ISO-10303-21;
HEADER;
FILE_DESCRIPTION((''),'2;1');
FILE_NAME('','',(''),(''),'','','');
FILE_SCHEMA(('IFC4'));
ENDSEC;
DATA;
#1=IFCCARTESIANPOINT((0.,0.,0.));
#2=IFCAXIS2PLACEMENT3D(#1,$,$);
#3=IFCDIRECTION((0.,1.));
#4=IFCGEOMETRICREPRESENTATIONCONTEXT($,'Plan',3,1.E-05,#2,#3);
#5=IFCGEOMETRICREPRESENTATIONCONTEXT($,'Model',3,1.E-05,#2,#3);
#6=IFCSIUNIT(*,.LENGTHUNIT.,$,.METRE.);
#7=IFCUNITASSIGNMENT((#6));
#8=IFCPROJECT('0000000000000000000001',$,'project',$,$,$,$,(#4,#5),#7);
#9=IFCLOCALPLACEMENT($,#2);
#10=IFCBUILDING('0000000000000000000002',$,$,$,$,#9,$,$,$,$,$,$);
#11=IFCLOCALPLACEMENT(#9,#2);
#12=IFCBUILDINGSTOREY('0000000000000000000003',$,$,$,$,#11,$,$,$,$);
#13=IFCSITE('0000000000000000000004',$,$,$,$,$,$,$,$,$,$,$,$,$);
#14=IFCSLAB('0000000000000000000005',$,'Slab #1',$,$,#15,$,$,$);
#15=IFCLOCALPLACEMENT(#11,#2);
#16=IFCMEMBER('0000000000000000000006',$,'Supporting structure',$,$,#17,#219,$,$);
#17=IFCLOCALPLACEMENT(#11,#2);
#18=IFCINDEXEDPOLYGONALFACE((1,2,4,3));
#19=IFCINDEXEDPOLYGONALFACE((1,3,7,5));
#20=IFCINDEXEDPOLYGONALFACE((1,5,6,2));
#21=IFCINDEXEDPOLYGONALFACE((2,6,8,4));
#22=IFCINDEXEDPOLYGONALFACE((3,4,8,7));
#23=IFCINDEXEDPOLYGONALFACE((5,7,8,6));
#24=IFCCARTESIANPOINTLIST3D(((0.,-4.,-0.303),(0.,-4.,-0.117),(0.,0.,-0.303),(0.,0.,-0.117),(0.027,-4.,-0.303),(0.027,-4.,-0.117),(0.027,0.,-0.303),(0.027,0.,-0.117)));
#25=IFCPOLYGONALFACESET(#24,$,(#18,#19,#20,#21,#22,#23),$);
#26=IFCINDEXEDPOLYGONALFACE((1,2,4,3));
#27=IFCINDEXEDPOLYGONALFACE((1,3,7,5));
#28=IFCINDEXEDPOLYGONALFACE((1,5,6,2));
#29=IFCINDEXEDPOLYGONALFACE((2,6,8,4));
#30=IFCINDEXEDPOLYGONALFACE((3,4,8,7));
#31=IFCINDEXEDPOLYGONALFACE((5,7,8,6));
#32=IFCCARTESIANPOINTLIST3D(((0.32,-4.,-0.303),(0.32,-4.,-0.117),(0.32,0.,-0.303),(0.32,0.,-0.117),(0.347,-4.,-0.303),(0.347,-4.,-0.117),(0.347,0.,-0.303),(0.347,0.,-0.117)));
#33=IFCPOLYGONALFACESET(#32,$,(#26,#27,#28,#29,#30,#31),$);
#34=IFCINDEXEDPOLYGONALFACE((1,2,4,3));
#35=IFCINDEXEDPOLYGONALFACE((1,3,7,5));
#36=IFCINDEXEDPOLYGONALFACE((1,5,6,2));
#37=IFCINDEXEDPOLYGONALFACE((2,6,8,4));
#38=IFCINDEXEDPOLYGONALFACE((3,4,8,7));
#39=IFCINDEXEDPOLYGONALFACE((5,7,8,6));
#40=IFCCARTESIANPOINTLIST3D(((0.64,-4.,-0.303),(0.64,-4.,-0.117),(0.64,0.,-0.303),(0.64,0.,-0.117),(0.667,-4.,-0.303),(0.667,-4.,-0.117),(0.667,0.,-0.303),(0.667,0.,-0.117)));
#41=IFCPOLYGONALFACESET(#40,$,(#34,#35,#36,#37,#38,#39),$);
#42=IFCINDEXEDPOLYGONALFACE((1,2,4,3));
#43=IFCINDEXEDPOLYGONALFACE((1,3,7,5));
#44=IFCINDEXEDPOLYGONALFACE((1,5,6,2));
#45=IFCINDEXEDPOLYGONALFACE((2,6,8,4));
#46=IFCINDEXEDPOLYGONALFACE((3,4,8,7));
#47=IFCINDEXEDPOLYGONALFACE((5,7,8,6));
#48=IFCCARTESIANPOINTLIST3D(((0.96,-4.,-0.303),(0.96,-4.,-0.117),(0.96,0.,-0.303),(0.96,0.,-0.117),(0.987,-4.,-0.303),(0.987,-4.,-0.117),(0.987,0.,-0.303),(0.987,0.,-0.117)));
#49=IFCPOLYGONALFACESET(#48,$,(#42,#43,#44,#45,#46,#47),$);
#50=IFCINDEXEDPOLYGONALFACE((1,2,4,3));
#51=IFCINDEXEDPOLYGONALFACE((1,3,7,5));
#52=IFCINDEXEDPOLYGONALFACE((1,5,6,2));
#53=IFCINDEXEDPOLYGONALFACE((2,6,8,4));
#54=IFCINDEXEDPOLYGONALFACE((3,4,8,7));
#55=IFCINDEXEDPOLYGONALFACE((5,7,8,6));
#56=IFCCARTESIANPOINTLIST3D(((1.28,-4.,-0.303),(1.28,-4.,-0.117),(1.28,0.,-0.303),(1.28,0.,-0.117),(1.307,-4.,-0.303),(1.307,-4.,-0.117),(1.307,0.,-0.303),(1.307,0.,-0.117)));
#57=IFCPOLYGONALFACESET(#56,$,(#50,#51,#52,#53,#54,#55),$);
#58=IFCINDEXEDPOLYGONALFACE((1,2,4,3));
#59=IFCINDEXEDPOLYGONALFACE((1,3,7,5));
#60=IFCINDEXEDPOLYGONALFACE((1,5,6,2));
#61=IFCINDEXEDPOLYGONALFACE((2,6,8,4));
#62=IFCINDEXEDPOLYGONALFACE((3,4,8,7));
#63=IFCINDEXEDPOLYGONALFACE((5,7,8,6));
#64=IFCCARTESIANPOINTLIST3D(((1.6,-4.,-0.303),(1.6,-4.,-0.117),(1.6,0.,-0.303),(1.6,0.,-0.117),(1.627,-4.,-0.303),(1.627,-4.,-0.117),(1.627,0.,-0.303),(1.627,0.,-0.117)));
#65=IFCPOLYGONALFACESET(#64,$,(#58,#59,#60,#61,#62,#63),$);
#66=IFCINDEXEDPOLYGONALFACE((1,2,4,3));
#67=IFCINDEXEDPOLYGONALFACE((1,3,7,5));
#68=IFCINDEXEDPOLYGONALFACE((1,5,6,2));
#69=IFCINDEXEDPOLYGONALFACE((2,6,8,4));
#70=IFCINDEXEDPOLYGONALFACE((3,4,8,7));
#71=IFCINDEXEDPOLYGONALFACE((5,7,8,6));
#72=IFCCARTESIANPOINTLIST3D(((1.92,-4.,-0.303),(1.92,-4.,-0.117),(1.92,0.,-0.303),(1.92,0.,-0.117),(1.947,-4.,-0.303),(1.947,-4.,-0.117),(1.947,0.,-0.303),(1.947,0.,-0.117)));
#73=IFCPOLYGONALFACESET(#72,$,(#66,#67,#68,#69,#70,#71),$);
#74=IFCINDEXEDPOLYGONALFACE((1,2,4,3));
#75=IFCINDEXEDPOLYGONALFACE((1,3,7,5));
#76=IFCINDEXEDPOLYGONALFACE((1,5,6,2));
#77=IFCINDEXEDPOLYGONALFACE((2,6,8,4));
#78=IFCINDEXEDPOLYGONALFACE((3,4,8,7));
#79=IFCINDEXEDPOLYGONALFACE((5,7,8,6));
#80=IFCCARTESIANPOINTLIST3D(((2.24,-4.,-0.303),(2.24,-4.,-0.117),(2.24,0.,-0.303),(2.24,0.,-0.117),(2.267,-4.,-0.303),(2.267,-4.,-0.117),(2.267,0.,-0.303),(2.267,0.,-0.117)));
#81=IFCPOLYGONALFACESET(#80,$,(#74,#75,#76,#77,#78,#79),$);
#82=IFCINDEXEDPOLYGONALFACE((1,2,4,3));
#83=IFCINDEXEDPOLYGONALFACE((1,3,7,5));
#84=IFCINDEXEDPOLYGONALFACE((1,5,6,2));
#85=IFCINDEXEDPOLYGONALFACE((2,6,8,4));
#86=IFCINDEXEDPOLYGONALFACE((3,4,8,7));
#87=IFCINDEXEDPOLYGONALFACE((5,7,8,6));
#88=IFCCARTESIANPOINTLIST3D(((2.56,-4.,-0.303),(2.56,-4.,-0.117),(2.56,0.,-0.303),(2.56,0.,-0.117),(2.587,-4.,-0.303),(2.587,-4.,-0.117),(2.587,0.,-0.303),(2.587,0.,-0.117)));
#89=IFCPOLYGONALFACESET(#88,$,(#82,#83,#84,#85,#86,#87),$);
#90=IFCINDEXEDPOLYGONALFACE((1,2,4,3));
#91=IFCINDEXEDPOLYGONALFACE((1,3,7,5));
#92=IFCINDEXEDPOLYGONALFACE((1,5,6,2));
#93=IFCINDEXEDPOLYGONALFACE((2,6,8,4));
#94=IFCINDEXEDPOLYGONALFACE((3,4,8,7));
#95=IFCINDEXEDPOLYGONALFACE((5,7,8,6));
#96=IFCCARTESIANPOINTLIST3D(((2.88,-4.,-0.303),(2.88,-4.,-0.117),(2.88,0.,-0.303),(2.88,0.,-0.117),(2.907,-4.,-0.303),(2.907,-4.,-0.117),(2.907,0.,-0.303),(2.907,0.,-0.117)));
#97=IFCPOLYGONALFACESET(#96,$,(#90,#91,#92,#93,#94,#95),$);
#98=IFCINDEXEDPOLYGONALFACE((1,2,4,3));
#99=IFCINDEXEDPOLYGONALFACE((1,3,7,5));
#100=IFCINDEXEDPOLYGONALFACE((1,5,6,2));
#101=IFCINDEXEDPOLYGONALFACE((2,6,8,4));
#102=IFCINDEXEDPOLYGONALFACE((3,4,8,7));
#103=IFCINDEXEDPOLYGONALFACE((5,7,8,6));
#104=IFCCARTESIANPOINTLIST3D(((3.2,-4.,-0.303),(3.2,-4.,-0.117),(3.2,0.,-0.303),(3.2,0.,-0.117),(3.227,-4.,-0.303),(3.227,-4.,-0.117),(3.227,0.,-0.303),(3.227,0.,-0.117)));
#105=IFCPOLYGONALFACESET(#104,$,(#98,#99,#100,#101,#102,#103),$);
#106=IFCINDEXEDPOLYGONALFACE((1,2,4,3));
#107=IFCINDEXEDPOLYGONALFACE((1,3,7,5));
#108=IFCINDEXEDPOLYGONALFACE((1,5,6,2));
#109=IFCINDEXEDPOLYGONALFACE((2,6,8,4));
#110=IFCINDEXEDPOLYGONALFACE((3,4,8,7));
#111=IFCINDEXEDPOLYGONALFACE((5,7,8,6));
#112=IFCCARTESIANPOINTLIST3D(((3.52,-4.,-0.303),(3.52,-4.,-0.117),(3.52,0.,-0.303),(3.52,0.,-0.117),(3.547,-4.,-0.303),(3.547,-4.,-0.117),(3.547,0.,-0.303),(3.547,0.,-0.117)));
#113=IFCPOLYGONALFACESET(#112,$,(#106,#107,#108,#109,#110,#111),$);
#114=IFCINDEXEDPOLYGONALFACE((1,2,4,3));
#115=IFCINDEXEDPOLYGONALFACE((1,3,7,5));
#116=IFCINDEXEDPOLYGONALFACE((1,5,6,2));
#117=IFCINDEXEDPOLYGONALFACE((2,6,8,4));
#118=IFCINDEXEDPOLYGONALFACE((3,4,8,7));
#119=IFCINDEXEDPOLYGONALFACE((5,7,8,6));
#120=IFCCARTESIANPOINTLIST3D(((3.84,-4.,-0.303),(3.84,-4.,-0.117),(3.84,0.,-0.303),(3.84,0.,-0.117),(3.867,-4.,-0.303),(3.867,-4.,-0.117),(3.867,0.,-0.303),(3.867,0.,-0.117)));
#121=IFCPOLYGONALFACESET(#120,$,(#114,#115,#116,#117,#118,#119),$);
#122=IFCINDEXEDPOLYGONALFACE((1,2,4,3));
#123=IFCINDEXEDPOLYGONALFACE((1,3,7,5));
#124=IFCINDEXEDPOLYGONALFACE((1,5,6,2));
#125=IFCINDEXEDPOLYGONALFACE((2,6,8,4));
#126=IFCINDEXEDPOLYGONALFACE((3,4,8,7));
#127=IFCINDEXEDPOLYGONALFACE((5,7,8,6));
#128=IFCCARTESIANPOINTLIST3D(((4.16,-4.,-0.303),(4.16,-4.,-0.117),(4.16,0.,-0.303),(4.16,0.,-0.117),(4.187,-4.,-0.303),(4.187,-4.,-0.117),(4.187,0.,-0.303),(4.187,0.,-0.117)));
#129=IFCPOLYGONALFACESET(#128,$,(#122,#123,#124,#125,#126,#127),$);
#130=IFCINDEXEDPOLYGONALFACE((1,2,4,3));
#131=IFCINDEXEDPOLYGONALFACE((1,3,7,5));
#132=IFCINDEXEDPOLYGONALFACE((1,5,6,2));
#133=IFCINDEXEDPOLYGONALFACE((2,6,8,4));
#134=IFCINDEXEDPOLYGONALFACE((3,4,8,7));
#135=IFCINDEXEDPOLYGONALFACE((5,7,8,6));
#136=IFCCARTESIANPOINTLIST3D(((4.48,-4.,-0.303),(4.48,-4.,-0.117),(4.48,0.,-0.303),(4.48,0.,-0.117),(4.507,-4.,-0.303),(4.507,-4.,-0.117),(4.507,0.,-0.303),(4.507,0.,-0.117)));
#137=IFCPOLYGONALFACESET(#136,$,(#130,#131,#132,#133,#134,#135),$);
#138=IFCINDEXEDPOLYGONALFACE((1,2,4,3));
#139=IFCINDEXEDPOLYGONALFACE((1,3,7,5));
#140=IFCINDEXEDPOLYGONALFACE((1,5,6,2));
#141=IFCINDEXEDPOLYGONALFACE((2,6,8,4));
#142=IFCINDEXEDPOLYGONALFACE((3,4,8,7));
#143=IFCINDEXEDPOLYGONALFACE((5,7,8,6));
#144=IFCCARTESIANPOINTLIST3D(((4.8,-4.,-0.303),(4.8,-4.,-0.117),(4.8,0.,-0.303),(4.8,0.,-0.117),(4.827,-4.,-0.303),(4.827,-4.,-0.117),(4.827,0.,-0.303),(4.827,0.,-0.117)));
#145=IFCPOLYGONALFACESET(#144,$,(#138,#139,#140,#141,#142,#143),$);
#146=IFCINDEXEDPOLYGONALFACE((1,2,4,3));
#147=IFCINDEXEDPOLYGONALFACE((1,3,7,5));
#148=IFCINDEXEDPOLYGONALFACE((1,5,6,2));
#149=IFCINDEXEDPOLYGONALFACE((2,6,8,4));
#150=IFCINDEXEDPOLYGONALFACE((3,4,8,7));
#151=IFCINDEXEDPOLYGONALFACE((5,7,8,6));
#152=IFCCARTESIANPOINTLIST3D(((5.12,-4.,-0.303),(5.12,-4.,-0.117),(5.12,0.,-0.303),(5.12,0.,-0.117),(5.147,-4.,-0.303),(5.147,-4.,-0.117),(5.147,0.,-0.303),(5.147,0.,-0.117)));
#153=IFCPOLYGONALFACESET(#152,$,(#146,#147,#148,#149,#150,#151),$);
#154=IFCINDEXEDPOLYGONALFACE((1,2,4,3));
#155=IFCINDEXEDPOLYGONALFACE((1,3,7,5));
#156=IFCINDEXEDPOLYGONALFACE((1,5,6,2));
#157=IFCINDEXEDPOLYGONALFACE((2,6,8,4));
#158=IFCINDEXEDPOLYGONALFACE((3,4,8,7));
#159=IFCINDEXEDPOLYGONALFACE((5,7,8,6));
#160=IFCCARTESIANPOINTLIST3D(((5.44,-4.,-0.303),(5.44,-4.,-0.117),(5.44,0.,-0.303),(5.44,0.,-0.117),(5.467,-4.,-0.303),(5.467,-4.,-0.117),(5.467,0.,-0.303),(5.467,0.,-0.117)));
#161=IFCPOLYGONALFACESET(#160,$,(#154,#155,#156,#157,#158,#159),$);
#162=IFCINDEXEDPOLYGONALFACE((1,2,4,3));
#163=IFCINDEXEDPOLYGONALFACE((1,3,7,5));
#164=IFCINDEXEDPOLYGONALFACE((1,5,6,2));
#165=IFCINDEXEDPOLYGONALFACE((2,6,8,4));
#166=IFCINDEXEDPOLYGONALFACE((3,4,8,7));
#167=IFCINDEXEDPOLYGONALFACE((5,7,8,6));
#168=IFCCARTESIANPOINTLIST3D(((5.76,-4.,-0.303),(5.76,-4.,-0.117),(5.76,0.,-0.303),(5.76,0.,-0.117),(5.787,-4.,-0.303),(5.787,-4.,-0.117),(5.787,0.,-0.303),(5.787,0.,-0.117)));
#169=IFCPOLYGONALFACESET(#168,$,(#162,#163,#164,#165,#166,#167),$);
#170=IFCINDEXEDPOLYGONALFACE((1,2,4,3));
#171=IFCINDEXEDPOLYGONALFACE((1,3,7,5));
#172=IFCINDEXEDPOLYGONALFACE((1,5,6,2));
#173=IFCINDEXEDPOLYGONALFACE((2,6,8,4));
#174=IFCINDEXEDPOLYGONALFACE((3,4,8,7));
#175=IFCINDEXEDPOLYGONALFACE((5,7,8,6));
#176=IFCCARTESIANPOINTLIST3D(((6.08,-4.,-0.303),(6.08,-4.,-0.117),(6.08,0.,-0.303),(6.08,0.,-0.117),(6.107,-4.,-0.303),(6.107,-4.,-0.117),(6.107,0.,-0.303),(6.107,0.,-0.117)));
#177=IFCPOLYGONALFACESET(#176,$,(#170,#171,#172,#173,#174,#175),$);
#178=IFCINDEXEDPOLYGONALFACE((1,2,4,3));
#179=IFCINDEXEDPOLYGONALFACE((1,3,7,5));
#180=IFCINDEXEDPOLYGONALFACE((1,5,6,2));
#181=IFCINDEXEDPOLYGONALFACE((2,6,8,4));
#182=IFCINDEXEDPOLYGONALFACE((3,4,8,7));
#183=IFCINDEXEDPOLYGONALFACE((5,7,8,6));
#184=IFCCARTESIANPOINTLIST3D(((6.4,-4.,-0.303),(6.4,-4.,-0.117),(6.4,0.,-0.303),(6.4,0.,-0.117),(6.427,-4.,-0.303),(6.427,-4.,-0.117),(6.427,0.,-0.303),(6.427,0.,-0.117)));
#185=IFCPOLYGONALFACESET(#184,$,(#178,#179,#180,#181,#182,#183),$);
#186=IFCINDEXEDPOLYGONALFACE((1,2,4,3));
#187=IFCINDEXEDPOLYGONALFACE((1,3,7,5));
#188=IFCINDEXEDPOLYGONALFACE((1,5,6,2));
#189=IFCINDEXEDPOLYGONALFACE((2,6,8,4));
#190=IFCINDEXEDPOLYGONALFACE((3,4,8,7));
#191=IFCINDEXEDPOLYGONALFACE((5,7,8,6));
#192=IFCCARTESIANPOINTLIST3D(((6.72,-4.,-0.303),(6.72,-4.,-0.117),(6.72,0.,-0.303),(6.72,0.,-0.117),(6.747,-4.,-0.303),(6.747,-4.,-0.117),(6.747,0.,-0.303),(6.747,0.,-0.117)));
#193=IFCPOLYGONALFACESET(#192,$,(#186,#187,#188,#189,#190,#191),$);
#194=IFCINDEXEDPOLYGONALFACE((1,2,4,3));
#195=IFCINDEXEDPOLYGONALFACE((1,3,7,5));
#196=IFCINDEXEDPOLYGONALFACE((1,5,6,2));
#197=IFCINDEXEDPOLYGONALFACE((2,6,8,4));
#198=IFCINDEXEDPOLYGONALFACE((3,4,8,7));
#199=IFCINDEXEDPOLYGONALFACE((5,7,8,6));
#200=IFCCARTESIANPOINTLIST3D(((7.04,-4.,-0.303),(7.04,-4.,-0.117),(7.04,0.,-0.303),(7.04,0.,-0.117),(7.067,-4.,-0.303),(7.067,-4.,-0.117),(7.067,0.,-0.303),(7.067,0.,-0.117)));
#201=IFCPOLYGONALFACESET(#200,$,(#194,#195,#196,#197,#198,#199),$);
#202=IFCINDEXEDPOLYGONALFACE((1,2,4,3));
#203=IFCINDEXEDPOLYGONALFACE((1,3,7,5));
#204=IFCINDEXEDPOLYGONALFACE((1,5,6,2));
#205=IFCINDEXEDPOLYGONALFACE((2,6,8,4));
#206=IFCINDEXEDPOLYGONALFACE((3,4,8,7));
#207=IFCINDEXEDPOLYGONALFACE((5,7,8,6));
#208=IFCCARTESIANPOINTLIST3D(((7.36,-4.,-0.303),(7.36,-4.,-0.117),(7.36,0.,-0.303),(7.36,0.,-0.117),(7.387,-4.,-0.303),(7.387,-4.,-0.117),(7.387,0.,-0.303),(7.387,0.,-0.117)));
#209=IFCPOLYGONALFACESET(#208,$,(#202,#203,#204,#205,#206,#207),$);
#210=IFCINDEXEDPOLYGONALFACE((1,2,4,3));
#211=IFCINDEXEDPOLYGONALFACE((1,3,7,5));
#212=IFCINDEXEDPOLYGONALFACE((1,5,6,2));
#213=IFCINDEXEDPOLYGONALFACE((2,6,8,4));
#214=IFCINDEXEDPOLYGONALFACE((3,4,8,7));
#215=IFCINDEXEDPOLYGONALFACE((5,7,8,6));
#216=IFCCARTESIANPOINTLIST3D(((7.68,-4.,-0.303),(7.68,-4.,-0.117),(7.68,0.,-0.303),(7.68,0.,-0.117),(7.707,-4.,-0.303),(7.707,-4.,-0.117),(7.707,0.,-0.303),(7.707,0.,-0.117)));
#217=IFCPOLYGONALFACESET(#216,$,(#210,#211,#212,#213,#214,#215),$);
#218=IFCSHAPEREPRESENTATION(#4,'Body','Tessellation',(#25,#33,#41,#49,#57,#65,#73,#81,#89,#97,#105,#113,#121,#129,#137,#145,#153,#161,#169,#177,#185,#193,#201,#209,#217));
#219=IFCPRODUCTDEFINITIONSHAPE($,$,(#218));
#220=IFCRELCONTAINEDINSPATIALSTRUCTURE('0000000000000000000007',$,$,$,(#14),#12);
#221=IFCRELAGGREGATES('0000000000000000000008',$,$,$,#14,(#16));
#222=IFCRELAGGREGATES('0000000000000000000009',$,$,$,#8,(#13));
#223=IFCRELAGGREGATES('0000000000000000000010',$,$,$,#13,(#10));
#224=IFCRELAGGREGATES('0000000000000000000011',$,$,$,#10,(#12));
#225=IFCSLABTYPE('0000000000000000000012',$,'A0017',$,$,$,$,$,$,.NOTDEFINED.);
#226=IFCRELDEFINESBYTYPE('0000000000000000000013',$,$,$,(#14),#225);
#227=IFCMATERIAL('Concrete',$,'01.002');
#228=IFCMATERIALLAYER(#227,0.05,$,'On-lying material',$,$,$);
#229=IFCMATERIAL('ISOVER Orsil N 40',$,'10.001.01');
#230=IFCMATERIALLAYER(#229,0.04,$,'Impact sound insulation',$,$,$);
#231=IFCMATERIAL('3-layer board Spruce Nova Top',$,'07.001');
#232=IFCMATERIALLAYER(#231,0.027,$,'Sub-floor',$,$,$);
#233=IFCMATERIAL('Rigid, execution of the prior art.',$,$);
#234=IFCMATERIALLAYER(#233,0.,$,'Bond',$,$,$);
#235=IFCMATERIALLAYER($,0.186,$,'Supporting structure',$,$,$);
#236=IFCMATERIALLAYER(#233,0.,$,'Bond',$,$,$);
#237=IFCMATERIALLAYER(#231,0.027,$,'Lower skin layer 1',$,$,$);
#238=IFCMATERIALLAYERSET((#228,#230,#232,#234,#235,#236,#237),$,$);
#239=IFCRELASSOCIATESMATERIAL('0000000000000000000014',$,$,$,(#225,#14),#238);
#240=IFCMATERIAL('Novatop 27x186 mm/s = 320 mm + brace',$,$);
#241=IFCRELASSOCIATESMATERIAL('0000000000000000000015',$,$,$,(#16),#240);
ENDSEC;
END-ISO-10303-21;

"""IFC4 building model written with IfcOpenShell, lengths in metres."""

from ifc_helpers import new_model, si_unit, direction, frame, frame_2d, origin, place, context, project, spatial, rectangle, extrude, material, layer, layer_set, type_object, element, aggregate, save


model = new_model("IFC4")

# Units and contexts
plan_context = context("Plan", 3, precision=1e-05, world=origin(), true_north=direction((0.0, 1.0)))
model_context = context("Model", 3, precision=1e-05, world=origin(), true_north=direction((0.0, 1.0)))
ifc_project = project(units=[si_unit("LENGTHUNIT", "METRE")], contexts=[plan_context, model_context])

# Site, building, storey
site = spatial("IfcSite", under=ifc_project)
building_placement = place(None, origin())
building = spatial("IfcBuilding", under=site, at=building_placement)
storey_placement = place(building_placement, origin())
storey = spatial("IfcBuildingStorey", under=building, at=storey_placement)

# Slab, member
ifc_material_1 = material(Name="Concrete", Category="01.002")
ifc_layer_1 = layer(ifc_material_1, 0.05, Name="On-lying material")
ifc_material_2 = material(Name="ISOVER Orsil N 40", Category="10.001.01")
ifc_layer_2 = layer(ifc_material_2, 0.04, Name="Impact sound insulation")
ifc_material_3 = material(Name="3-layer board Spruce Nova Top", Category="07.001")
ifc_layer_3 = layer(ifc_material_3, 0.027, Name="Sub-floor")
ifc_material_4 = material(Name="Rigid, execution of the prior art.")
ifc_layer_4 = layer(ifc_material_4, 0.0, Name="Bond")
ifc_layer_5 = layer(None, 0.186, Name="Supporting structure")
ifc_layer_6 = layer(ifc_material_4, 0.0, Name="Bond")
ifc_layer_7 = layer(ifc_material_3, 0.027, Name="Lower skin layer 1")
ifc_layer_set = layer_set([ifc_layer_1, ifc_layer_2, ifc_layer_3, ifc_layer_4, ifc_layer_5, ifc_layer_6, ifc_layer_7])
slab_type = type_object("IfcSlabType", Name="A0017", PredefinedType="NOTDEFINED", material=ifc_layer_set)
slab_placement = place(None, frame((0.0, 0.0, 0.0), z_axis=(0.0, 0.0, -1.0), x_axis=(1.0, 0.0, 0.0)))
slab = element("IfcSlab", 1, at=slab_placement, inside=storey, type_object=slab_type, material=ifc_layer_set, Name="Slab #1")
ifc_material_5 = material(Name="Novatop 27x186 mm/s = 320 mm + brace")
member_1_placement = place(slab_placement, origin())
member_1 = element("IfcMember", 2, at=member_1_placement, material=ifc_material_5, Name="Supporting structure", context=plan_context, shape_type="SweptSolid", body=[
    extrude(rectangle(XDim=0.027, YDim=0.186, at=frame_2d((0.0135, 0.093), x_axis=(1.0, 0.0))), frame((0.0, 4.0, 0.117), z_axis=(0.0, -1.0, 0.0), x_axis=(1.0, 0.0, 0.0)), (0.0, 0.0, 1.0), 4.0),
    extrude(rectangle(XDim=0.027, YDim=0.186, at=frame_2d((0.0135, 0.093), x_axis=(1.0, 0.0))), frame((0.32, 4.0, 0.117), z_axis=(0.0, -1.0, 0.0), x_axis=(1.0, 0.0, 0.0)), (0.0, 0.0, 1.0), 4.0),
    extrude(rectangle(XDim=0.027, YDim=0.186, at=frame_2d((0.0135, 0.093), x_axis=(1.0, 0.0))), frame((0.64, 4.0, 0.117), z_axis=(0.0, -1.0, 0.0), x_axis=(1.0, 0.0, 0.0)), (0.0, 0.0, 1.0), 4.0),
    extrude(rectangle(XDim=0.027, YDim=0.186, at=frame_2d((0.0135, 0.093), x_axis=(1.0, 0.0))), frame((0.96, 4.0, 0.117), z_axis=(0.0, -1.0, 0.0), x_axis=(1.0, 0.0, 0.0)), (0.0, 0.0, 1.0), 4.0),
    extrude(rectangle(XDim=0.027, YDim=0.186, at=frame_2d((0.0135, 0.093), x_axis=(1.0, 0.0))), frame((1.28, 4.0, 0.117), z_axis=(0.0, -1.0, 0.0), x_axis=(1.0, 0.0, 0.0)), (0.0, 0.0, 1.0), 4.0),
    extrude(rectangle(XDim=0.027, YDim=0.186, at=frame_2d((0.0135, 0.093), x_axis=(1.0, 0.0))), frame((1.6, 4.0, 0.117), z_axis=(0.0, -1.0, 0.0), x_axis=(1.0, 0.0, 0.0)), (0.0, 0.0, 1.0), 4.0),
    extrude(rectangle(XDim=0.027, YDim=0.186, at=frame_2d((0.0135, 0.093), x_axis=(1.0, 0.0))), frame((1.92, 4.0, 0.117), z_axis=(0.0, -1.0, 0.0), x_axis=(1.0, 0.0, 0.0)), (0.0, 0.0, 1.0), 4.0),
    extrude(rectangle(XDim=0.027, YDim=0.186, at=frame_2d((0.0135, 0.093), x_axis=(1.0, 0.0))), frame((2.24, 4.0, 0.117), z_axis=(0.0, -1.0, 0.0), x_axis=(1.0, 0.0, 0.0)), (0.0, 0.0, 1.0), 4.0),
    extrude(rectangle(XDim=0.027, YDim=0.186, at=frame_2d((0.0135, 0.093), x_axis=(1.0, 0.0))), frame((2.56, 4.0, 0.117), z_axis=(0.0, -1.0, 0.0), x_axis=(1.0, 0.0, 0.0)), (0.0, 0.0, 1.0), 4.0),
    extrude(rectangle(XDim=0.027, YDim=0.186, at=frame_2d((0.0135, 0.093), x_axis=(1.0, 0.0))), frame((2.88, 4.0, 0.117), z_axis=(0.0, -1.0, 0.0), x_axis=(1.0, 0.0, 0.0)), (0.0, 0.0, 1.0), 4.0),
    extrude(rectangle(XDim=0.027, YDim=0.186, at=frame_2d((0.0135, 0.093), x_axis=(1.0, 0.0))), frame((3.2, 4.0, 0.117), z_axis=(0.0, -1.0, 0.0), x_axis=(1.0, 0.0, 0.0)), (0.0, 0.0, 1.0), 4.0),
    extrude(rectangle(XDim=0.027, YDim=0.186, at=frame_2d((0.0135, 0.093), x_axis=(1.0, 0.0))), frame((3.52, 4.0, 0.117), z_axis=(0.0, -1.0, 0.0), x_axis=(1.0, 0.0, 0.0)), (0.0, 0.0, 1.0), 4.0),
    extrude(rectangle(XDim=0.027, YDim=0.186, at=frame_2d((0.0135, 0.093), x_axis=(1.0, 0.0))), frame((3.84, 4.0, 0.117), z_axis=(0.0, -1.0, 0.0), x_axis=(1.0, 0.0, 0.0)), (0.0, 0.0, 1.0), 4.0),
    extrude(rectangle(XDim=0.027, YDim=0.186, at=frame_2d((0.0135, 0.093), x_axis=(1.0, 0.0))), frame((4.16, 4.0, 0.117), z_axis=(0.0, -1.0, 0.0), x_axis=(1.0, 0.0, 0.0)), (0.0, 0.0, 1.0), 4.0),
    extrude(rectangle(XDim=0.027, YDim=0.186, at=frame_2d((0.0135, 0.093), x_axis=(1.0, 0.0))), frame((4.48, 4.0, 0.117), z_axis=(0.0, -1.0, 0.0), x_axis=(1.0, 0.0, 0.0)), (0.0, 0.0, 1.0), 4.0),
    extrude(rectangle(XDim=0.027, YDim=0.186, at=frame_2d((0.0135, 0.093), x_axis=(1.0, 0.0))), frame((4.8, 4.0, 0.117), z_axis=(0.0, -1.0, 0.0), x_axis=(1.0, 0.0, 0.0)), (0.0, 0.0, 1.0), 4.0),
    extrude(rectangle(XDim=0.027, YDim=0.186, at=frame_2d((0.0135, 0.093), x_axis=(1.0, 0.0))), frame((5.12, 4.0, 0.117), z_axis=(0.0, -1.0, 0.0), x_axis=(1.0, 0.0, 0.0)), (0.0, 0.0, 1.0), 4.0),
    extrude(rectangle(XDim=0.027, YDim=0.186, at=frame_2d((0.0135, 0.093), x_axis=(1.0, 0.0))), frame((5.44, 4.0, 0.117), z_axis=(0.0, -1.0, 0.0), x_axis=(1.0, 0.0, 0.0)), (0.0, 0.0, 1.0), 4.0),
    extrude(rectangle(XDim=0.027, YDim=0.186, at=frame_2d((0.0135, 0.093), x_axis=(1.0, 0.0))), frame((5.76, 4.0, 0.117), z_axis=(0.0, -1.0, 0.0), x_axis=(1.0, 0.0, 0.0)), (0.0, 0.0, 1.0), 4.0),
    extrude(rectangle(XDim=0.027, YDim=0.186, at=frame_2d((0.0135, 0.093), x_axis=(1.0, 0.0))), frame((6.08, 4.0, 0.117), z_axis=(0.0, -1.0, 0.0), x_axis=(1.0, 0.0, 0.0)), (0.0, 0.0, 1.0), 4.0),
    extrude(rectangle(XDim=0.027, YDim=0.186, at=frame_2d((0.0135, 0.093), x_axis=(1.0, 0.0))), frame((6.4, 4.0, 0.117), z_axis=(0.0, -1.0, 0.0), x_axis=(1.0, 0.0, 0.0)), (0.0, 0.0, 1.0), 4.0),
    extrude(rectangle(XDim=0.027, YDim=0.186, at=frame_2d((0.0135, 0.093), x_axis=(1.0, 0.0))), frame((6.72, 4.0, 0.117), z_axis=(0.0, -1.0, 0.0), x_axis=(1.0, 0.0, 0.0)), (0.0, 0.0, 1.0), 4.0),
    extrude(rectangle(XDim=0.027, YDim=0.186, at=frame_2d((0.0135, 0.093), x_axis=(1.0, 0.0))), frame((7.04, 4.0, 0.117), z_axis=(0.0, -1.0, 0.0), x_axis=(1.0, 0.0, 0.0)), (0.0, 0.0, 1.0), 4.0),
    extrude(rectangle(XDim=0.027, YDim=0.186, at=frame_2d((0.0135, 0.093), x_axis=(1.0, 0.0))), frame((7.36, 4.0, 0.117), z_axis=(0.0, -1.0, 0.0), x_axis=(1.0, 0.0, 0.0)), (0.0, 0.0, 1.0), 4.0),
    extrude(rectangle(XDim=0.027, YDim=0.186, at=frame_2d((0.0135, 0.093), x_axis=(1.0, 0.0))), frame((7.68, 4.0, 0.117), z_axis=(0.0, -1.0, 0.0), x_axis=(1.0, 0.0, 0.0)), (0.0, 0.0, 1.0), 4.0),
])
aggregate(slab, [member_1])

save(model, "model.ifc")
